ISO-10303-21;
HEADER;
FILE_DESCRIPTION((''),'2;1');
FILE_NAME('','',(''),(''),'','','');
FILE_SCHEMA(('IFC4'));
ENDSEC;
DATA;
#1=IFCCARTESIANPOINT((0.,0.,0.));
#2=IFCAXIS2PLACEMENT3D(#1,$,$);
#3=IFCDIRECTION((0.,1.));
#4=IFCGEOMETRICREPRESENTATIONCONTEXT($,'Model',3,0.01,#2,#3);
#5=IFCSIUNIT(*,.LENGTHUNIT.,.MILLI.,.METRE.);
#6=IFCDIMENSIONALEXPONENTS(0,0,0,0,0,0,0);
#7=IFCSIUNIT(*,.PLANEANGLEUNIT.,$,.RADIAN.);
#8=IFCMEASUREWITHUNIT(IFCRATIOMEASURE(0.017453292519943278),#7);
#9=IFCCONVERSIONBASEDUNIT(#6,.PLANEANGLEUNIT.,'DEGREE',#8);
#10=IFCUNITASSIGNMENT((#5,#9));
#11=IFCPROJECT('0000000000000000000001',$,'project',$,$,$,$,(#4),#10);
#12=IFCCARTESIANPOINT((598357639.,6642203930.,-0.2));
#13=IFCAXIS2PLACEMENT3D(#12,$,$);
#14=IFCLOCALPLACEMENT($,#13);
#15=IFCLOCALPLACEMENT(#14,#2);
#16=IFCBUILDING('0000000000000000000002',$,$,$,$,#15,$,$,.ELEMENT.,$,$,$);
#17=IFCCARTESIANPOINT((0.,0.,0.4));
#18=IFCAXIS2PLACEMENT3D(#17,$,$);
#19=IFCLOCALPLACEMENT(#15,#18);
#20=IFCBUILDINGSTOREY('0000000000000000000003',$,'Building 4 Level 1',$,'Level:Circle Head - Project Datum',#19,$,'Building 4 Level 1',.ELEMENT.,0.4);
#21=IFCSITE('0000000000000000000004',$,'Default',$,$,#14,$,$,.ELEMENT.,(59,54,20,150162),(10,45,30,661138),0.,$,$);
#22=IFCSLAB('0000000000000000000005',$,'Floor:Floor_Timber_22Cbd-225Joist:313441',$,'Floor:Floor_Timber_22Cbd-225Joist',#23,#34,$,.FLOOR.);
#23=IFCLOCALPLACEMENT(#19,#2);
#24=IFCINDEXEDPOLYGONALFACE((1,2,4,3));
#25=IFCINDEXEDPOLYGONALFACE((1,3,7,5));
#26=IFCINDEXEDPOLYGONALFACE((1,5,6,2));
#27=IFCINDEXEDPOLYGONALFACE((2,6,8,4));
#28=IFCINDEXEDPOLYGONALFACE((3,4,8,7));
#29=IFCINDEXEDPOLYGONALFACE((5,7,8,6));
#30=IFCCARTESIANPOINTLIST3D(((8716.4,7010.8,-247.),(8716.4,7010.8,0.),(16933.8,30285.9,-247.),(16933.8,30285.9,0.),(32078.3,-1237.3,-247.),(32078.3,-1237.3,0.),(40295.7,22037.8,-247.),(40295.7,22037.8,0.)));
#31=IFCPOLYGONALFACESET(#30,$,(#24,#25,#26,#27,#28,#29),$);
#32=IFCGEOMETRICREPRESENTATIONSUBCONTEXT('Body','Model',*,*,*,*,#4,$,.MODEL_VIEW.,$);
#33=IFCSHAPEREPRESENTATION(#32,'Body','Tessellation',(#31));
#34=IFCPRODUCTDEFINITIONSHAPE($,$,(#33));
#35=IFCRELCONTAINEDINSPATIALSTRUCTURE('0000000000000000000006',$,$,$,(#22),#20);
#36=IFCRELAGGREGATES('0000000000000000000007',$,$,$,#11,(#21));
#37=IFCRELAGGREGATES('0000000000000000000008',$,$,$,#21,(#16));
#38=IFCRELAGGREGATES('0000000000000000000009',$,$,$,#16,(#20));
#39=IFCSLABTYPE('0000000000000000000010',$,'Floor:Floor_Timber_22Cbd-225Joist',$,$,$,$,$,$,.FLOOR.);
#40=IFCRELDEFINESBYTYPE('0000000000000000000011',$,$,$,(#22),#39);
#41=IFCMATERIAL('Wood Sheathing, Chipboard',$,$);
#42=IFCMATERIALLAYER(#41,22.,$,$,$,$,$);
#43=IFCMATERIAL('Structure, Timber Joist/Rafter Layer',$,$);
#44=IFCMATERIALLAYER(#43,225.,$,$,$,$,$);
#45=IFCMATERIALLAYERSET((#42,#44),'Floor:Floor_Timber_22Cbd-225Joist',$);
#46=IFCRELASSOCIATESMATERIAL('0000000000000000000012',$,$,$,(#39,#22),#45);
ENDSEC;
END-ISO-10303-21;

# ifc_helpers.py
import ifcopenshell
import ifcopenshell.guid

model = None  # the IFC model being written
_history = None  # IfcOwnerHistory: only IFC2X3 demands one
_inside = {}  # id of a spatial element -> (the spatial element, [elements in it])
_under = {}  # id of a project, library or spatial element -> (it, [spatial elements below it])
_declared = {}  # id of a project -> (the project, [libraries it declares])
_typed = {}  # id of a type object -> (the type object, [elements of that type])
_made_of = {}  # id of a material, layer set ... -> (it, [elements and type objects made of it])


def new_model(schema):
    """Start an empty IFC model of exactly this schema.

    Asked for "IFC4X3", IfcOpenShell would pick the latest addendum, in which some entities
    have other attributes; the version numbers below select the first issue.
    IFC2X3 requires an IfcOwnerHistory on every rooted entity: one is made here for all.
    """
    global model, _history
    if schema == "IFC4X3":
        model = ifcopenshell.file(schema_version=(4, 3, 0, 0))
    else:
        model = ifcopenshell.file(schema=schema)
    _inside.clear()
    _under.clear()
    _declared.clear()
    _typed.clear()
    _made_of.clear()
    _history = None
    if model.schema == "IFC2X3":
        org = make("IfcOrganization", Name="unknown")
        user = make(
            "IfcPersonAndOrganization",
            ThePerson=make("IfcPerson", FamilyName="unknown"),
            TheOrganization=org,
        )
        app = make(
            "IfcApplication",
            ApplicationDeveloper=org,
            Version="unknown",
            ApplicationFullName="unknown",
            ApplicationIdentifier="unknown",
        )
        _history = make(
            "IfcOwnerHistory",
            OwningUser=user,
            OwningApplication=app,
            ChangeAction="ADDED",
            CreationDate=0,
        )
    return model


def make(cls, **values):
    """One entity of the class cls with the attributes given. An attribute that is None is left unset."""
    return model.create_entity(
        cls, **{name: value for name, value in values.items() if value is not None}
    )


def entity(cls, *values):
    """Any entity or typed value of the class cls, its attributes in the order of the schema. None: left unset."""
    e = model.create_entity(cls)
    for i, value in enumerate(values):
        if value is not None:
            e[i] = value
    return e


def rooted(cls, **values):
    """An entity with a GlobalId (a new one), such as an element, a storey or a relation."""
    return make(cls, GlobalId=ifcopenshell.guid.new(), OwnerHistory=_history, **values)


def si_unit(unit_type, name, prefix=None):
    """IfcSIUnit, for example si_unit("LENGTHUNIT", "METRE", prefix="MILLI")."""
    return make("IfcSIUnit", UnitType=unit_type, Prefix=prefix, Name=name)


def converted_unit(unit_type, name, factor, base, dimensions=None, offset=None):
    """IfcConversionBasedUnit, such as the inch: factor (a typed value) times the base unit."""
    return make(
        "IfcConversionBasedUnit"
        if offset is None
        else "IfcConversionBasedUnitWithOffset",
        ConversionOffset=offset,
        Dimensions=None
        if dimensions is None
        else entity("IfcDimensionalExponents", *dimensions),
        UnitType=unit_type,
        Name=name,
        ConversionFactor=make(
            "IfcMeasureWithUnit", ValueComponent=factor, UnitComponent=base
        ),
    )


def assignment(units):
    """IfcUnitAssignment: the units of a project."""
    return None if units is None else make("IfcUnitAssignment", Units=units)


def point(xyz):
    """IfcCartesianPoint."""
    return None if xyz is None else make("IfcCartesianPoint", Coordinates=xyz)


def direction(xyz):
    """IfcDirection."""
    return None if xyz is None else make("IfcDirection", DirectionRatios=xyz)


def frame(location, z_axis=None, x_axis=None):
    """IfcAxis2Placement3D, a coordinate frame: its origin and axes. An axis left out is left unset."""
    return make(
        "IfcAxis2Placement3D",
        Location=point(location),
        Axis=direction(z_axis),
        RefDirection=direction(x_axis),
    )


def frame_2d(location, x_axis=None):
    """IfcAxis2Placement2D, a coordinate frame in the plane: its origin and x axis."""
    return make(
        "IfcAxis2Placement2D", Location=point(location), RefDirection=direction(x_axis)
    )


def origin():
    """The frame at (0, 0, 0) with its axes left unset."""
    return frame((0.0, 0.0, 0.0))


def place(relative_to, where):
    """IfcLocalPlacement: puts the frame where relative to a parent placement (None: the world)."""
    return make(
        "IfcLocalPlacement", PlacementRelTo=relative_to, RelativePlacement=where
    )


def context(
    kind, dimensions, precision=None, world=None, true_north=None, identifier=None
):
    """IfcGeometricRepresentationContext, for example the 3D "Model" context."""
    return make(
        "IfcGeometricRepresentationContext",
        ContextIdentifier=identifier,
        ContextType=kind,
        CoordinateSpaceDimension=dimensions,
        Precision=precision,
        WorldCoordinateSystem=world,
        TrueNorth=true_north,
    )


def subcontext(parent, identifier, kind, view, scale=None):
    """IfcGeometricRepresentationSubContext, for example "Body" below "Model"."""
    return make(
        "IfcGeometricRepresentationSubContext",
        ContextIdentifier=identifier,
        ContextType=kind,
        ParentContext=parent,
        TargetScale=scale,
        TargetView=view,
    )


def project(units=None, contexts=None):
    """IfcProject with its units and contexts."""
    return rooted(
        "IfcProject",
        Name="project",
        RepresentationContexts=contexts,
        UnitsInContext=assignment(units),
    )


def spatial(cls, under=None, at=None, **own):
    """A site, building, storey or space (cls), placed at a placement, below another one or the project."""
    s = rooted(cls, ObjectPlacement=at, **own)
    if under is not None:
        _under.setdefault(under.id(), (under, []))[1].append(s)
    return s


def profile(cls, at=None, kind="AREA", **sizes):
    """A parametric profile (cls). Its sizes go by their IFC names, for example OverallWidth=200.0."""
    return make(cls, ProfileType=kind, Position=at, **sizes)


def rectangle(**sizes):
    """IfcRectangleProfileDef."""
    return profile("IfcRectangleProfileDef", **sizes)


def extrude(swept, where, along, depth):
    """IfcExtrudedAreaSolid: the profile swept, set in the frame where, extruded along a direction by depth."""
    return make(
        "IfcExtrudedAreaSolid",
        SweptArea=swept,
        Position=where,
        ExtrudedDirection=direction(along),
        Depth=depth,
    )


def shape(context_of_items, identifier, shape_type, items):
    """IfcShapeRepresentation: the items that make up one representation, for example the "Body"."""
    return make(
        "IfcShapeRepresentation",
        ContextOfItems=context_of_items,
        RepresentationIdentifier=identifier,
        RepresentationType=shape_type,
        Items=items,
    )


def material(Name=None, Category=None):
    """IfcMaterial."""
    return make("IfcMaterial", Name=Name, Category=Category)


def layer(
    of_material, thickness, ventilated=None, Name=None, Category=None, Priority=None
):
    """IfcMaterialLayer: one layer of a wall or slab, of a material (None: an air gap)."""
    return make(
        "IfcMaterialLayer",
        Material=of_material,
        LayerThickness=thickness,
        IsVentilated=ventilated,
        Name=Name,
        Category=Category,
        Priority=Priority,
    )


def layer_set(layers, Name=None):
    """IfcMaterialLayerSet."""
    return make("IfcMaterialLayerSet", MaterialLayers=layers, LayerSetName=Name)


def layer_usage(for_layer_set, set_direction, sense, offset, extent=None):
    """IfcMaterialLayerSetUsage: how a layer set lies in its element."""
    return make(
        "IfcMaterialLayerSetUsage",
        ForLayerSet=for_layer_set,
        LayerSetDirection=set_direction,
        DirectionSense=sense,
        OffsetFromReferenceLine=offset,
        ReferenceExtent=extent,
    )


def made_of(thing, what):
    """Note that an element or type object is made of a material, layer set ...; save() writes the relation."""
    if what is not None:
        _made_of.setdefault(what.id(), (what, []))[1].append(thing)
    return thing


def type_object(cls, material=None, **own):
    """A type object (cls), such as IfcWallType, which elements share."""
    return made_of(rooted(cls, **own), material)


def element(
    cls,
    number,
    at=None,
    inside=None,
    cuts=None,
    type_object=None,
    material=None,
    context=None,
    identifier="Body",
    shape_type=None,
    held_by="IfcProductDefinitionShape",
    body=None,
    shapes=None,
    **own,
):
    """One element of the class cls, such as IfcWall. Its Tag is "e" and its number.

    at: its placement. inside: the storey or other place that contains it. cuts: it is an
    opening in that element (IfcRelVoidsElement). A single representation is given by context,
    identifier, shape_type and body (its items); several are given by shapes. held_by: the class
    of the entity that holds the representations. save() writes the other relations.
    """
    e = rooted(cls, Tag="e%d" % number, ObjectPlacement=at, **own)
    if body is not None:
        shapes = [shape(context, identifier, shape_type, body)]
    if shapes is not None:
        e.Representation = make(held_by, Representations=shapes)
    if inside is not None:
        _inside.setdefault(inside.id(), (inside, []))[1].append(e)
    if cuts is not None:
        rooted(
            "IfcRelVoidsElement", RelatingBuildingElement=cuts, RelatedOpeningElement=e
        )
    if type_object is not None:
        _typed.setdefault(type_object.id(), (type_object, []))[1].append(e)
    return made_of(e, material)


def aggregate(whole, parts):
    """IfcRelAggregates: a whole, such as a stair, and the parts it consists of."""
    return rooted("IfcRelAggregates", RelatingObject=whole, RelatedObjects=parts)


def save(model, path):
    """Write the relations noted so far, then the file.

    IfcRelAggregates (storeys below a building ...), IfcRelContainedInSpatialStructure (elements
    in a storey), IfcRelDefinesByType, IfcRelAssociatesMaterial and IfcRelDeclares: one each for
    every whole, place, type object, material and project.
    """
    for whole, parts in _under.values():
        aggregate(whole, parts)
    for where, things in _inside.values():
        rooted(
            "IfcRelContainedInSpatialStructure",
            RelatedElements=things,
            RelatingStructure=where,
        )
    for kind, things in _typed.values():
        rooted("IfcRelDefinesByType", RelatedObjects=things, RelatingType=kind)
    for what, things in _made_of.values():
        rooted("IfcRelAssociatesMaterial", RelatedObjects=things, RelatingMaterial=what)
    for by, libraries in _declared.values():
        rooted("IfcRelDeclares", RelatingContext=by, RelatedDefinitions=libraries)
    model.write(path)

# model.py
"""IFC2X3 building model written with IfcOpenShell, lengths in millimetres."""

from ifc_helpers import new_model, entity, si_unit, converted_unit, direction, frame, frame_2d, origin, place, context, subcontext, project, spatial, rectangle, extrude, material, layer, layer_set, layer_usage, type_object, element, save


model = new_model("IFC2X3")

# Units and contexts
model_context = context("Model", 3, precision=0.01, world=origin(), true_north=direction((0.0, 1.0)))
body_context = subcontext(model_context, "Body", "Model", "MODEL_VIEW")
ifc_project = project(units=[si_unit("LENGTHUNIT", "METRE", prefix="MILLI"), converted_unit("PLANEANGLEUNIT", "DEGREE", entity("IfcRatioMeasure", 0.017453292519943278), si_unit("PLANEANGLEUNIT", "RADIAN"), dimensions=[0, 0, 0, 0, 0, 0, 0])], contexts=[model_context])

# Site, building, storey
site_placement = place(None, frame((598357639.0, 6642203930.0, -0.2)))
site = spatial("IfcSite", under=ifc_project, at=site_placement, Name="Default", CompositionType="ELEMENT", RefLatitude=(59, 54, 20, 150162), RefLongitude=(10, 45, 30, 661138), RefElevation=0.0)
building_placement = place(site_placement, origin())
building = spatial("IfcBuilding", under=site, at=building_placement, CompositionType="ELEMENT")
storey_placement = place(building_placement, frame((0.0, 0.0, 0.4)))
storey = spatial("IfcBuildingStorey", under=building, at=storey_placement, Name="Building 4 Level 1", ObjectType="Level:Circle Head - Project Datum", LongName="Building 4 Level 1", CompositionType="ELEMENT", Elevation=0.4)

# Slab
ifc_material_1 = material(Name="Wood Sheathing, Chipboard")
ifc_layer_1 = layer(ifc_material_1, 22.0)
ifc_material_2 = material(Name="Structure, Timber Joist/Rafter Layer")
ifc_layer_2 = layer(ifc_material_2, 225.0)
ifc_layer_set = layer_set([ifc_layer_1, ifc_layer_2], Name="Floor:Floor_Timber_22Cbd-225Joist")
ifc_layer_usage = layer_usage(ifc_layer_set, "AXIS3", "POSITIVE", 0.0)
slab_type = type_object("IfcSlabType", Name="Floor:Floor_Timber_22Cbd-225Joist", PredefinedType="FLOOR", material=ifc_layer_set)
slab_placement = place(storey_placement, origin())
element("IfcSlab", 1, at=slab_placement, inside=storey, type_object=slab_type, material=ifc_layer_usage, Name="Floor:Floor_Timber_22Cbd-225Joist:313441", ObjectType="Floor:Floor_Timber_22Cbd-225Joist", PredefinedType="FLOOR", context=body_context, shape_type="SweptSolid", body=[
    extrude(rectangle(XDim=24683.1, YDim=24775.2, at=frame_2d((0.0, 0.0), x_axis=(1.0, 0.0))), frame((24506.0, 14524.3, 0.0), z_axis=(0.0, 0.0, -1.0), x_axis=(-0.332918, -0.942956, 0.0)), (0.0, 0.0, 1.0), 247.0),
])

save(model, "model.ifc")
